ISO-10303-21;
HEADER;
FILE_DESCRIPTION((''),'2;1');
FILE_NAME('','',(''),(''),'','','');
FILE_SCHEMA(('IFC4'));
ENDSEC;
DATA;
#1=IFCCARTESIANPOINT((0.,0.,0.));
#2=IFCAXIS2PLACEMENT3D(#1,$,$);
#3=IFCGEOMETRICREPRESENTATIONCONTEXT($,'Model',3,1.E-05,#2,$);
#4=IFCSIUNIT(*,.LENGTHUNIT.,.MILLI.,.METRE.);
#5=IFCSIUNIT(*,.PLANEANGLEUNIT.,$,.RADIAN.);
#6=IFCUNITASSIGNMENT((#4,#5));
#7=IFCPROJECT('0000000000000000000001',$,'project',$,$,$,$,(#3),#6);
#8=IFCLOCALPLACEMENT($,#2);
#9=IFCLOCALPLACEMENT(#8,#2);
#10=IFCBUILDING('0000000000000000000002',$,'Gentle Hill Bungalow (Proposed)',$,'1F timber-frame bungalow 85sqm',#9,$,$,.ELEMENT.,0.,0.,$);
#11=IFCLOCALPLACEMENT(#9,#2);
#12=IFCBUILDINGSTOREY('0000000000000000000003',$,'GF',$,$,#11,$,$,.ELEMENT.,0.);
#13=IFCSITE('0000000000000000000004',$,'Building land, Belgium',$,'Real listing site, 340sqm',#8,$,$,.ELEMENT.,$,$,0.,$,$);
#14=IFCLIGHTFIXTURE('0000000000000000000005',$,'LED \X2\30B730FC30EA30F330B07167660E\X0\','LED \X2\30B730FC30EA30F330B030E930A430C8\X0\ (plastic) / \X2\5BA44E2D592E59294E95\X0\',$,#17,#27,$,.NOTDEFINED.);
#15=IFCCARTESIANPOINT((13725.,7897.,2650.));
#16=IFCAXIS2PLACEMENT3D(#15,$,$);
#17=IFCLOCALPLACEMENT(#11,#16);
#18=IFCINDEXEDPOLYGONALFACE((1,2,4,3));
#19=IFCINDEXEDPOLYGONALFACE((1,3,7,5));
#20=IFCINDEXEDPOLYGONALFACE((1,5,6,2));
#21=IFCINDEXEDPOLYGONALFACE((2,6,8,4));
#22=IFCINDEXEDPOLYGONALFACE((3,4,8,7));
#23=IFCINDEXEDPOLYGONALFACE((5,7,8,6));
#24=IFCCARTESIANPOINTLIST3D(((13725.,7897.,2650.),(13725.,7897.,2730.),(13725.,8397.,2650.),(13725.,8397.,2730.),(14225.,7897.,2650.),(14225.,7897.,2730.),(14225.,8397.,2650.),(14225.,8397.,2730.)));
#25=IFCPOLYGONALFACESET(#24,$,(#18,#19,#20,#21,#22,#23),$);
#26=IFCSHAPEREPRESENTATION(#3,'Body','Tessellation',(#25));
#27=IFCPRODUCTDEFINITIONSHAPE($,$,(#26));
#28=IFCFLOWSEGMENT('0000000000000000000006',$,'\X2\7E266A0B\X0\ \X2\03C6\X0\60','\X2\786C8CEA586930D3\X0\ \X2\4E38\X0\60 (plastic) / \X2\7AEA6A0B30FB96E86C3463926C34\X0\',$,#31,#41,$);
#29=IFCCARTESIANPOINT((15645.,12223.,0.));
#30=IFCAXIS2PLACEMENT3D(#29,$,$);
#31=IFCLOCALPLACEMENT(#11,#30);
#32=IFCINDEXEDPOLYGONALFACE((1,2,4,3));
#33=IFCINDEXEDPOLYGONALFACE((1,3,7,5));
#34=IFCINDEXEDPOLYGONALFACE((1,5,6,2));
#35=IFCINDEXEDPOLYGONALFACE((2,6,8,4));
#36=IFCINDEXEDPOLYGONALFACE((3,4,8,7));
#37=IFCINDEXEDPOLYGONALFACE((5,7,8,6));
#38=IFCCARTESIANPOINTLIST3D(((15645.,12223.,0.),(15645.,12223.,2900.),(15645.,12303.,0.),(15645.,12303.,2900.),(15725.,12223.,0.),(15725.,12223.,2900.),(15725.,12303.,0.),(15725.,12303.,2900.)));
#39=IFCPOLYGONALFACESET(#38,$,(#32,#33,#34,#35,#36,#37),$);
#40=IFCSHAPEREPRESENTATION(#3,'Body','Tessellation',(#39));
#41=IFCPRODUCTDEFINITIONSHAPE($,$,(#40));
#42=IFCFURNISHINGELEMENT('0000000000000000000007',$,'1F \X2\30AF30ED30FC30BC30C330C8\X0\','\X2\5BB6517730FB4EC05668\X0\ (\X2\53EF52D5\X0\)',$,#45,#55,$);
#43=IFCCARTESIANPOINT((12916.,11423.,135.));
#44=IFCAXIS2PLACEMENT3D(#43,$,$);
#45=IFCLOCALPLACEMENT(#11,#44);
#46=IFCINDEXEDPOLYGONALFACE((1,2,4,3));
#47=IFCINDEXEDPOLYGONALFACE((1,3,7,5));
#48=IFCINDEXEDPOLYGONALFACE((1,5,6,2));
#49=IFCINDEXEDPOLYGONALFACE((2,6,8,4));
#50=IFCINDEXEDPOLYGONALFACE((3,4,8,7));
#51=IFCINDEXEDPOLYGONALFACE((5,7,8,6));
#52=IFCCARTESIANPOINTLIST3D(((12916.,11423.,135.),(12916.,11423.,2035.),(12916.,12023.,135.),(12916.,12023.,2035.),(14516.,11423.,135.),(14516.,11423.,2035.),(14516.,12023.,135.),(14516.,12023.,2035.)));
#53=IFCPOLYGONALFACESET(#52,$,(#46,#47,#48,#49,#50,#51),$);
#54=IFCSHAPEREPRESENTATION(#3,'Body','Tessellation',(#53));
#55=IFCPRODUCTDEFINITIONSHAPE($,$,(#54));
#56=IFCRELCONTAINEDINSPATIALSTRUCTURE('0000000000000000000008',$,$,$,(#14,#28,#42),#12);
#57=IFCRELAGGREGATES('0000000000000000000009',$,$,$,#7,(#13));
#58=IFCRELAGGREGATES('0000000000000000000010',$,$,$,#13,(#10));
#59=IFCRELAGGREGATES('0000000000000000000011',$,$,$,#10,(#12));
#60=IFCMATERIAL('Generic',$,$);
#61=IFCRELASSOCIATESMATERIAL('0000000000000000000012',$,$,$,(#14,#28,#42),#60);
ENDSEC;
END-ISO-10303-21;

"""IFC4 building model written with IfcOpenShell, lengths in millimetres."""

from ifc_helpers import new_model, si_unit, frame, frame_2d, origin, place, context, project, spatial, rectangle, extrude, material, element, save


model = new_model("IFC4")

# Units and contexts
model_context = context("Model", 3, precision=1e-05, world=origin())
ifc_project = project(units=[si_unit("LENGTHUNIT", "METRE", prefix="MILLI"), si_unit("PLANEANGLEUNIT", "RADIAN")], contexts=[model_context])

# Site, building, storey
site_placement = place(None, origin())
site = spatial("IfcSite", under=ifc_project, at=site_placement, Name="Building land, Belgium", ObjectType="Real listing site, 340sqm", CompositionType="ELEMENT", RefElevation=0.0)
building_placement = place(site_placement, origin())
building = spatial("IfcBuilding", under=site, at=building_placement, Name="Gentle Hill Bungalow (Proposed)", ObjectType="1F timber-frame bungalow 85sqm", CompositionType="ELEMENT", ElevationOfRefHeight=0.0, ElevationOfTerrain=0.0)
storey_placement = place(building_placement, origin())
storey = spatial("IfcBuildingStorey", under=building, at=storey_placement, Name="GF", CompositionType="ELEMENT", Elevation=0.0)

# Shared definitions
ifc_material_1 = material(Name="Generic")

# Light fixture
light_fixture_1_placement = place(storey_placement, frame((13725.0, 7897.0, 2650.0)))
element("IfcLightFixture", 1, at=light_fixture_1_placement, inside=storey, material=ifc_material_1, Name="LED シーリング照明", Description="LED シーリングライト (plastic) / 室中央天井", PredefinedType="NOTDEFINED", context=model_context, shape_type="SweptSolid", body=[
    extrude(rectangle(XDim=500.0, YDim=500.0, at=frame_2d((250.0, 250.0))), frame((13725.0, 7897.0, 2650.0)), (0.0, 0.0, 1.0), 80.0),
])

# Flow segment
flow_segment_placement = place(storey_placement, frame((15645.0, 12223.0, 0.0)))
element("IfcFlowSegment", 2, at=flow_segment_placement, inside=storey, material=ifc_material_1, Name="縦樋 φ60", Description="硬質塩ビ 丸60 (plastic) / 竪樋・雨水排水", context=model_context, shape_type="SweptSolid", body=[
    extrude(rectangle(XDim=80.0, YDim=80.0, at=frame_2d((40.0, 40.0))), frame((15645.0, 12223.0, 0.0)), (0.0, 0.0, 1.0), 2900.0),
])

# Furnishing element
furnishing_placement = place(storey_placement, frame((12916.0, 11423.0, 135.0)))
element("IfcFurnishingElement", 3, at=furnishing_placement, inside=storey, material=ifc_material_1, Name="1F クローゼット", Description="家具・什器 (可動)", context=model_context, shape_type="SweptSolid", body=[
    extrude(rectangle(XDim=1600.0, YDim=600.0, at=frame_2d((800.0, 300.0))), frame((12916.0, 11423.0, 135.0)), (0.0, 0.0, 1.0), 1900.0),
])

save(model, "model.ifc")
